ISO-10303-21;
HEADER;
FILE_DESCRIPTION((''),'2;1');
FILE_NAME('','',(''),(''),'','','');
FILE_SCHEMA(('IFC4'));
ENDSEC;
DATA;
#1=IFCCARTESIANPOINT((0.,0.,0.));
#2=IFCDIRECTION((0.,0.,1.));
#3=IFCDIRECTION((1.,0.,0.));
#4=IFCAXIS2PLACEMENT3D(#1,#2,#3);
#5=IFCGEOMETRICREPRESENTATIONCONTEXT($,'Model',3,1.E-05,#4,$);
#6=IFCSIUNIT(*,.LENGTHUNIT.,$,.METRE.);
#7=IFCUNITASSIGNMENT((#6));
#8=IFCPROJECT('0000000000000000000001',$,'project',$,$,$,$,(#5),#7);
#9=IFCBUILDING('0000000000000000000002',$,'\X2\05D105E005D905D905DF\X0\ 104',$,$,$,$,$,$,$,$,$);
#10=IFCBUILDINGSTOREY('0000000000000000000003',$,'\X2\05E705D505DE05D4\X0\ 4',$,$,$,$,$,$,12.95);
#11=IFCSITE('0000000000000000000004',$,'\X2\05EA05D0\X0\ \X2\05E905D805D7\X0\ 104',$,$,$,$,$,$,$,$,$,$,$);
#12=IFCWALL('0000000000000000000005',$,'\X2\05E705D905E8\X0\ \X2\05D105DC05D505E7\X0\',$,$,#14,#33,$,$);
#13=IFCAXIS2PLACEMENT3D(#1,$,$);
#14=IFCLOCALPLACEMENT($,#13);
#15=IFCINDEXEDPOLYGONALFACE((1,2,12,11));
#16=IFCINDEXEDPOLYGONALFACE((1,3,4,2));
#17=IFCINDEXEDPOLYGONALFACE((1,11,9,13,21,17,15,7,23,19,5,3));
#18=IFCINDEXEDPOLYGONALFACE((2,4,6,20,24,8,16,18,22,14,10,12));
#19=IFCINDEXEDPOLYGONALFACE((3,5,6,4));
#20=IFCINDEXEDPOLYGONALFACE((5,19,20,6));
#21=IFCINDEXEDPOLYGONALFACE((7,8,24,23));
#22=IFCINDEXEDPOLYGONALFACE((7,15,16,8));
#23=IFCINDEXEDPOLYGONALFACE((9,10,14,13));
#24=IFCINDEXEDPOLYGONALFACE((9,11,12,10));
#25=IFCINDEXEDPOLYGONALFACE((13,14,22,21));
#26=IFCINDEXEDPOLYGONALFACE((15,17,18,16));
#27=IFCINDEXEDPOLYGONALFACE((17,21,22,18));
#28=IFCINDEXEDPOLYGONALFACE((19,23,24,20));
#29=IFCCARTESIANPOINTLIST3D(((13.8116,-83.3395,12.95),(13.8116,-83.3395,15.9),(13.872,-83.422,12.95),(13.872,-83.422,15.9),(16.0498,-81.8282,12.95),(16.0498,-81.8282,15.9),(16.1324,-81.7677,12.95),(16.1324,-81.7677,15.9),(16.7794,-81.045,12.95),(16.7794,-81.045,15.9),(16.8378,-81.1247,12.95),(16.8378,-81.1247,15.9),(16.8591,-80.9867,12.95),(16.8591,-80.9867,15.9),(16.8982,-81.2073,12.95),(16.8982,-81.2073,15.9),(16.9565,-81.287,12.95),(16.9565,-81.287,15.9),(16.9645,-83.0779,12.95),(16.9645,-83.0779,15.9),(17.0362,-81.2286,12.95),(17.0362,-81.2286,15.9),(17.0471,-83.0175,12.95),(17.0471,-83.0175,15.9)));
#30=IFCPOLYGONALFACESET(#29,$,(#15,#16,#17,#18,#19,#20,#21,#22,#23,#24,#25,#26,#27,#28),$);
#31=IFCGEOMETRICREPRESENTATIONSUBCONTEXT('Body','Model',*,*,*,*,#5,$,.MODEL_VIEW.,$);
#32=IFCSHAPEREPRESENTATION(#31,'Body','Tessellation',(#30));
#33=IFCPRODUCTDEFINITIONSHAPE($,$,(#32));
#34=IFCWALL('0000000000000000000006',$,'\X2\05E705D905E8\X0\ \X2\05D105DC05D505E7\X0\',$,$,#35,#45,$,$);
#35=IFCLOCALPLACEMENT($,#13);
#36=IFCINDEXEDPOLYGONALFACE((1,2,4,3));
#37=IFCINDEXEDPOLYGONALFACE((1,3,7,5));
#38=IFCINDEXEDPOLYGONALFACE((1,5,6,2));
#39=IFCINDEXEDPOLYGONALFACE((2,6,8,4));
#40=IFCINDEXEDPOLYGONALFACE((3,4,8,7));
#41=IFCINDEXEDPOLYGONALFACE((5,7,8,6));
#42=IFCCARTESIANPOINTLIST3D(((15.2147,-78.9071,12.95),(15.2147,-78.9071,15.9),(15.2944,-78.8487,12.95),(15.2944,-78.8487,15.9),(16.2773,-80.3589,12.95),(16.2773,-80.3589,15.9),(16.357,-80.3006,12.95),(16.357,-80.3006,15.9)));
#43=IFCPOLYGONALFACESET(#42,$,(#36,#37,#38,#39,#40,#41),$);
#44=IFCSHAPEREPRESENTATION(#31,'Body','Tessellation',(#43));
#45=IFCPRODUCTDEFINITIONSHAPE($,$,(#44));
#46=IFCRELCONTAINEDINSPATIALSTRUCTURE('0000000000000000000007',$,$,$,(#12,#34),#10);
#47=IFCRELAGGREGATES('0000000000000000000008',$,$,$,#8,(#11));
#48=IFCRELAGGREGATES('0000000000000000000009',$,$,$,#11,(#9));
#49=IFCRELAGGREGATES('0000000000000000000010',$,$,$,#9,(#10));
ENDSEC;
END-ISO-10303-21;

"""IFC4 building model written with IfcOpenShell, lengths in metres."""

from ifc_helpers import new_model, si_unit, frame, origin_with_axes, context, subcontext, project, spatial, polyline, outline, extrude, element, save


model = new_model("IFC4")

# Units and contexts
model_context = context("Model", 3, precision=1e-05, world=origin_with_axes())
body_context = subcontext(model_context, "Body", "Model", "MODEL_VIEW")
ifc_project = project(units=[si_unit("LENGTHUNIT", "METRE")], contexts=[model_context])

# Site, building, storey
site = spatial("IfcSite", under=ifc_project, Name="תא שטח 104")
building = spatial("IfcBuilding", under=site, Name="בניין 104")
storey = spatial("IfcBuildingStorey", under=building, Name="קומה 4", Elevation=12.95)

# Walls
element("IfcWall", 1, inside=storey, Name="קיר בלוק", context=body_context, shape_type="SweptSolid", body=[
    extrude(outline(polyline([(16.8378, -81.1247), (13.8116, -83.3395), (13.872, -83.422), (16.0498, -81.8282), (16.9645, -83.0779), (17.0471, -83.0175), (16.1324, -81.7677), (16.8982, -81.2073), (16.9565, -81.287), (17.0362, -81.2286), (16.8591, -80.9867), (16.7794, -81.045), (16.8378, -81.1247)])), frame((0.0, 0.0, 12.95)), (0.0, 0.0, 1.0), 2.95),
])
element("IfcWall", 2, inside=storey, Name="קיר בלוק", context=body_context, shape_type="SweptSolid", body=[
    extrude(outline(polyline([(16.357, -80.3006), (15.2944, -78.8487), (15.2147, -78.9071), (16.2773, -80.3589), (16.357, -80.3006)])), frame((0.0, 0.0, 12.95)), (0.0, 0.0, 1.0), 2.95),
])

save(model, "model.ifc")
